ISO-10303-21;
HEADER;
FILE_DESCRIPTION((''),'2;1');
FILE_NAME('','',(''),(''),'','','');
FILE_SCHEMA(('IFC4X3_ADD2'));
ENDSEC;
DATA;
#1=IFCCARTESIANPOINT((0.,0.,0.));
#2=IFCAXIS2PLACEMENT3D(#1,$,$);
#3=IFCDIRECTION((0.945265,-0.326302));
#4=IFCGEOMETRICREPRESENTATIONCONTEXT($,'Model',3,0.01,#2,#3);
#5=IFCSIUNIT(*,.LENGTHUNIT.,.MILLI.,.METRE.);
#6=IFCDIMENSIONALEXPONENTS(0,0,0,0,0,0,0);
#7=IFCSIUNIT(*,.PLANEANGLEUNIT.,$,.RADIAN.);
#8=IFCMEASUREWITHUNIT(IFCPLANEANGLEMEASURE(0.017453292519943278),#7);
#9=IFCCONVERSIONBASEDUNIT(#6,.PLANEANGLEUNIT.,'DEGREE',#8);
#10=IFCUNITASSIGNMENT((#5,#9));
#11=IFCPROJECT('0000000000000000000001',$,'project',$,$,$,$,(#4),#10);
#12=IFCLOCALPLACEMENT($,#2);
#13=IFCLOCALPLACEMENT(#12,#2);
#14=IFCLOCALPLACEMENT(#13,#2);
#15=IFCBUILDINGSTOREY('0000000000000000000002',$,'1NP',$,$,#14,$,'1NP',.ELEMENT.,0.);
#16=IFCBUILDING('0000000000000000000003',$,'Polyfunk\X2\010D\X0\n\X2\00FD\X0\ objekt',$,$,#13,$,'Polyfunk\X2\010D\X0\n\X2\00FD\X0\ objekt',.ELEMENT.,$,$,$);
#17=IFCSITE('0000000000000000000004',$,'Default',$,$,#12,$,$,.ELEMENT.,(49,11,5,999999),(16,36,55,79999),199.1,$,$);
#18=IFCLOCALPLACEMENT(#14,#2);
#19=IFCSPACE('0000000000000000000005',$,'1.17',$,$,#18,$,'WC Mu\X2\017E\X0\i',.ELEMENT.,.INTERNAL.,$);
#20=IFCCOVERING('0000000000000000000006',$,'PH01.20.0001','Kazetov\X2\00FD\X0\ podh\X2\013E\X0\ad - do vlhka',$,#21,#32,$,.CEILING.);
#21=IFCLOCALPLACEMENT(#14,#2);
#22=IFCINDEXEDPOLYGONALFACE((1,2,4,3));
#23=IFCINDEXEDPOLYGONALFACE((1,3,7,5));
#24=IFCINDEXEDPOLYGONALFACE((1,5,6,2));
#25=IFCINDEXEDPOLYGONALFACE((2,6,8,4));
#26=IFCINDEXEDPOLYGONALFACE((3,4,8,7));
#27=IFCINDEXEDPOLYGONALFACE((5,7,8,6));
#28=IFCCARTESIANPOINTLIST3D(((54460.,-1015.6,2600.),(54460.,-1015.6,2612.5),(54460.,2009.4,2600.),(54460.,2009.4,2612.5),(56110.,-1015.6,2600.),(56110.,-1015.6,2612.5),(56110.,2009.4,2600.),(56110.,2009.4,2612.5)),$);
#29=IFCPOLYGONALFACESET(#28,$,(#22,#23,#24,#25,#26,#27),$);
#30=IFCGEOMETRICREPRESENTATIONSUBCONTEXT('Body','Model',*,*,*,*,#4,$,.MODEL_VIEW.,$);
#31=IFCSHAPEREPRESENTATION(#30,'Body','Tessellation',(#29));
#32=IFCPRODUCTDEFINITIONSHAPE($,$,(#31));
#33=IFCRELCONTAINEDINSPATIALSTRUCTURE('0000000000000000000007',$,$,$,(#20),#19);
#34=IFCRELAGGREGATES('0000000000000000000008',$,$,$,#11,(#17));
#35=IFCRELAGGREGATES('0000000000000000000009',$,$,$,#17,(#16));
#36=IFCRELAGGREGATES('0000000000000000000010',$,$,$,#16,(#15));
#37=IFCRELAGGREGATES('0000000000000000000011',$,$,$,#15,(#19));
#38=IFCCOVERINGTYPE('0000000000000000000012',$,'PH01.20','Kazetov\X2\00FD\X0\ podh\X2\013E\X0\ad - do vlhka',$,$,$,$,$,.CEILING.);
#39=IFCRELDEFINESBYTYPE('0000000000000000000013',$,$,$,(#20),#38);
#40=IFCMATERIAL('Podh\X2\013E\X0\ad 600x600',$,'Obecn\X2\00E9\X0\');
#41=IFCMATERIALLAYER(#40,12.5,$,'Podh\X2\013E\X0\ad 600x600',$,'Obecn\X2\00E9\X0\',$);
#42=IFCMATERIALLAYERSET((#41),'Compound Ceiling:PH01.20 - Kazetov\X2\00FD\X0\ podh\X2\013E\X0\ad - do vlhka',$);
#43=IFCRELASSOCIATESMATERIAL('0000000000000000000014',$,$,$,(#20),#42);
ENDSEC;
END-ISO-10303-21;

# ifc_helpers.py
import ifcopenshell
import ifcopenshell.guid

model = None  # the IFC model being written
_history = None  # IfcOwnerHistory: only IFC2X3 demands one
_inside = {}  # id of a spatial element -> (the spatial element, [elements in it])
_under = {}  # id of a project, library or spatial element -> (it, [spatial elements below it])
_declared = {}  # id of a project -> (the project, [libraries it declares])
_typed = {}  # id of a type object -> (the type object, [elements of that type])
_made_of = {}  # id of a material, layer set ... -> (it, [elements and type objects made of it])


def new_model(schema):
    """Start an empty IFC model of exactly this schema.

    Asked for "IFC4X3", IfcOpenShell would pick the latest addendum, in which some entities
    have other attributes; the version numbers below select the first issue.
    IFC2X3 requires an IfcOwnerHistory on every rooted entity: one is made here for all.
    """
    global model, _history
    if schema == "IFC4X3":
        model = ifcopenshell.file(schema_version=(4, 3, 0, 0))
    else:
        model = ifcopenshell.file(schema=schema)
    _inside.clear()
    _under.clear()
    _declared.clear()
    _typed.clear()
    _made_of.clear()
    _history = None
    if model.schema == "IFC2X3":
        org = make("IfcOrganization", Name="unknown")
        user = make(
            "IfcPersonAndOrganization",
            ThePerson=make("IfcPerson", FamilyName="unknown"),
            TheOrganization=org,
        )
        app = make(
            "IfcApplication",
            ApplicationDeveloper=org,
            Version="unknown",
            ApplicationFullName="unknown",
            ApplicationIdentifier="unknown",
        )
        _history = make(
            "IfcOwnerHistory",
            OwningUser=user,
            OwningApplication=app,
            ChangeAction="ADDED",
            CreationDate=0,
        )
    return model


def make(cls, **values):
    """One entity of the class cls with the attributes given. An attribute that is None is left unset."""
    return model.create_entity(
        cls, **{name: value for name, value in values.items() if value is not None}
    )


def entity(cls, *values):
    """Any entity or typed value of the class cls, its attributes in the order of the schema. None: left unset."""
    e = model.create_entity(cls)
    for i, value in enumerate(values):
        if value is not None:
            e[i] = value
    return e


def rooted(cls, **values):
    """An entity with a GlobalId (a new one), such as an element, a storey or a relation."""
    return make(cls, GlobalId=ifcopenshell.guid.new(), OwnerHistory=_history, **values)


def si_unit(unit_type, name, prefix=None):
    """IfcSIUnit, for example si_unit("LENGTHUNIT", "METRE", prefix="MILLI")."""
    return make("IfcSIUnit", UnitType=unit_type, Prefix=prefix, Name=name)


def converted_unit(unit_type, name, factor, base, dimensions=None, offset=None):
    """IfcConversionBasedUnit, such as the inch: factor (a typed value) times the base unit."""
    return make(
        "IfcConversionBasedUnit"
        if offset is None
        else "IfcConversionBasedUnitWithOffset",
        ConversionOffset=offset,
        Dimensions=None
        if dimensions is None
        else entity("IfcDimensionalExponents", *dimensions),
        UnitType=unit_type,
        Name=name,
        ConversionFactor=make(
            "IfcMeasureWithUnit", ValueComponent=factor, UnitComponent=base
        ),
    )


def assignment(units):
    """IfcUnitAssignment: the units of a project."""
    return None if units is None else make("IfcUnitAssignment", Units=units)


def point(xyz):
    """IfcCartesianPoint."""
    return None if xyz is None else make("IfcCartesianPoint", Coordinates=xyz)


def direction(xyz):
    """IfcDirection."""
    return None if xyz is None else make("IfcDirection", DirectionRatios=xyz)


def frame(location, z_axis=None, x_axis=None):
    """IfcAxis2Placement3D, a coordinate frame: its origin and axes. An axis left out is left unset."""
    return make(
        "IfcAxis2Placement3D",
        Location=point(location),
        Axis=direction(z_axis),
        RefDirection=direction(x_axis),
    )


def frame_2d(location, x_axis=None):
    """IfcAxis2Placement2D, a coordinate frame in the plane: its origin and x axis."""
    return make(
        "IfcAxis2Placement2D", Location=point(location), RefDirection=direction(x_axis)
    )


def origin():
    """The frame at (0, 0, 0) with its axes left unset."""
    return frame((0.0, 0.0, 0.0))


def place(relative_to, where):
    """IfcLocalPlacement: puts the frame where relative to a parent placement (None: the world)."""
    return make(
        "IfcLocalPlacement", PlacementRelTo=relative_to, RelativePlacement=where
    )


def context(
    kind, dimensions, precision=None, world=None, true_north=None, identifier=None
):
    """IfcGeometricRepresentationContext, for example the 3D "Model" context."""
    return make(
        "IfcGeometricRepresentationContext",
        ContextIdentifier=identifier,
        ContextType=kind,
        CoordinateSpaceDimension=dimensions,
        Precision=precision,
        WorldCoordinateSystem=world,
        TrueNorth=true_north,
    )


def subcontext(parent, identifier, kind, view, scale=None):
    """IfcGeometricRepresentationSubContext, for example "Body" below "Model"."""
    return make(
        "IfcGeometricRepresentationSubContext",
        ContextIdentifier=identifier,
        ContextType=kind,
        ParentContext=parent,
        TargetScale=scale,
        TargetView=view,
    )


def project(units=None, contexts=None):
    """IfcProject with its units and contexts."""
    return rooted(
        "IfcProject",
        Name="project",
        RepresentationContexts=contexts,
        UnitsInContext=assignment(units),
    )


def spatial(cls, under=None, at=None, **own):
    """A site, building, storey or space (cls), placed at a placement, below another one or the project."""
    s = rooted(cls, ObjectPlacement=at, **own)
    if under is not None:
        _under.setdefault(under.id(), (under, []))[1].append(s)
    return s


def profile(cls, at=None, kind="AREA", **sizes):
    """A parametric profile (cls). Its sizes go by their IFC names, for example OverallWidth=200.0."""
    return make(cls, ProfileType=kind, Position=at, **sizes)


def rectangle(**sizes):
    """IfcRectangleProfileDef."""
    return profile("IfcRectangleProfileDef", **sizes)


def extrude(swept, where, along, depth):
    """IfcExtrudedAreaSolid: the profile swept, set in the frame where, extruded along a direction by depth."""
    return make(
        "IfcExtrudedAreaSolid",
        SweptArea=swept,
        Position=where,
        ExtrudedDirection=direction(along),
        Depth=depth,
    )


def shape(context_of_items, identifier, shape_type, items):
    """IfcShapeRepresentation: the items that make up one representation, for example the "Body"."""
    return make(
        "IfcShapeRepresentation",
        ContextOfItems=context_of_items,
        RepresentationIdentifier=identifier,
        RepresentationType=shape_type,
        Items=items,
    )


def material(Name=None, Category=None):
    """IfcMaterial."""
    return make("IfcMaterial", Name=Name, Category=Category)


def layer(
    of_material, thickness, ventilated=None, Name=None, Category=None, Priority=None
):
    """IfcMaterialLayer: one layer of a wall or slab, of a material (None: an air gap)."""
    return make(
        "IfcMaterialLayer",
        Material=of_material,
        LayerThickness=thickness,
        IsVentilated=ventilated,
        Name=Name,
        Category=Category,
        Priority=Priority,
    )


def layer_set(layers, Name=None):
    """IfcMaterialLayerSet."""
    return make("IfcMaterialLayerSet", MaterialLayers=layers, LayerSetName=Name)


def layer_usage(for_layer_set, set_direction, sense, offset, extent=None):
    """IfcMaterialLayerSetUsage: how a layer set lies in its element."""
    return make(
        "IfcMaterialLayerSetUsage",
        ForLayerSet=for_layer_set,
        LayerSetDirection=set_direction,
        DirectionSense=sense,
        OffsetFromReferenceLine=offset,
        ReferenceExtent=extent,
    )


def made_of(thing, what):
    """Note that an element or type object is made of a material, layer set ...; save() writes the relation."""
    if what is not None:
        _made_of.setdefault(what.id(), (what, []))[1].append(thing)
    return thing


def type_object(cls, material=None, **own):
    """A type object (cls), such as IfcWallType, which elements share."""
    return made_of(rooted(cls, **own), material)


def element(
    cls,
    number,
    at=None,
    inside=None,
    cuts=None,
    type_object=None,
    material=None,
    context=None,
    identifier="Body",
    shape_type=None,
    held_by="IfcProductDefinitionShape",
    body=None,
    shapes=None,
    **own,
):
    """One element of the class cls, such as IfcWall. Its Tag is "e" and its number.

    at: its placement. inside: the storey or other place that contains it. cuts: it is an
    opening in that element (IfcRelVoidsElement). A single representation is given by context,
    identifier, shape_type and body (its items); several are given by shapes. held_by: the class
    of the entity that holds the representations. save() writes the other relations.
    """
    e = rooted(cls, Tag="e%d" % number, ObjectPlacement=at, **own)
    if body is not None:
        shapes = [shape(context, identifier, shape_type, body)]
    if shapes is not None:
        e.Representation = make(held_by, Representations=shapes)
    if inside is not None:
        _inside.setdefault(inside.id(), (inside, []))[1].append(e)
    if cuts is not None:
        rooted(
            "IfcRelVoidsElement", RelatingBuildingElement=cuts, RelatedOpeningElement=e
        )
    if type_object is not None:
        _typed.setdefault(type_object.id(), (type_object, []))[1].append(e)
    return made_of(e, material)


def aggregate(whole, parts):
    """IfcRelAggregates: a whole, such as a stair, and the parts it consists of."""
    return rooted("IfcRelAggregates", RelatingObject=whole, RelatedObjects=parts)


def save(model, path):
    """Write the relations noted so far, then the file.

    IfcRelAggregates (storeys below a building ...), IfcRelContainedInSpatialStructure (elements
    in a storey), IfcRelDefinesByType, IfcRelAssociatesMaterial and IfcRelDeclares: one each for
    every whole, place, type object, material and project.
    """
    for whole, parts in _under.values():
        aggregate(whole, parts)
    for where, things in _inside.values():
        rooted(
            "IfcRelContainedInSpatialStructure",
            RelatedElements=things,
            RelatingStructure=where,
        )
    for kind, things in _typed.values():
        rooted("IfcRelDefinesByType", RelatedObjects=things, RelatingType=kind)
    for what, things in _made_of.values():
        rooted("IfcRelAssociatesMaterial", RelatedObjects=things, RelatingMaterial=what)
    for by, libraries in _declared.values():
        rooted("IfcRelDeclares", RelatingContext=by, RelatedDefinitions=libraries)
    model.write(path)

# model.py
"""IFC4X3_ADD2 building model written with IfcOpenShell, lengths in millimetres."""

from ifc_helpers import new_model, entity, si_unit, converted_unit, direction, frame, frame_2d, origin, place, context, subcontext, project, spatial, rectangle, extrude, material, layer, layer_set, layer_usage, type_object, element, save


model = new_model("IFC4X3_ADD2")

# Units and contexts
model_context = context("Model", 3, precision=0.01, world=origin(), true_north=direction((0.945265, -0.326302)))
body_context = subcontext(model_context, "Body", "Model", "MODEL_VIEW")
ifc_project = project(units=[si_unit("LENGTHUNIT", "METRE", prefix="MILLI"), converted_unit("PLANEANGLEUNIT", "DEGREE", entity("IfcPlaneAngleMeasure", 0.017453292519943278), si_unit("PLANEANGLEUNIT", "RADIAN"), dimensions=[0, 0, 0, 0, 0, 0, 0])], contexts=[model_context])

# Site, building, storey
site_placement = place(None, origin())
site = spatial("IfcSite", under=ifc_project, at=site_placement, Name="Default", CompositionType="ELEMENT", RefLatitude=(49, 11, 5, 999999), RefLongitude=(16, 36, 55, 79999), RefElevation=199.1)
building_placement = place(site_placement, origin())
building = spatial("IfcBuilding", under=site, at=building_placement, Name="Polyfunkčný objekt", LongName="Polyfunkčný objekt", CompositionType="ELEMENT")
storey_placement = place(building_placement, origin())
storey = spatial("IfcBuildingStorey", under=building, at=storey_placement, Name="1NP", LongName="1NP", CompositionType="ELEMENT", Elevation=0.0)

# Shared definitions
ifc_material_1 = material(Name="Podhľad 600x600", Category="Obecné")

# Shared definitions
ifc_layer_1 = layer(ifc_material_1, 12.5, Name="Podhľad 600x600", Category="Obecné")
ifc_layer_set_1 = layer_set([ifc_layer_1], Name="Compound Ceiling:PH01.20 - Kazetový podhľad - do vlhka")
covering_type_1 = type_object("IfcCoveringType", Name="PH01.20", Description="Kazetový podhľad - do vlhka", PredefinedType="CEILING")

# Shared definitions
space_1_placement = place(storey_placement, origin())
space_1 = spatial("IfcSpace", under=storey, at=space_1_placement, Name="1.17", LongName="WC Muži", CompositionType="ELEMENT", PredefinedType="INTERNAL")

# Covering
ifc_layer_usage_1 = layer_usage(ifc_layer_set_1, "AXIS3", "NEGATIVE", 0.0)
covering_1_placement = place(storey_placement, frame((54460.0, -1015.6, 2600.0)))
element("IfcCovering", 1, at=covering_1_placement, inside=space_1, type_object=covering_type_1, material=ifc_layer_usage_1, Name="PH01.20.0001", Description="Kazetový podhľad - do vlhka", PredefinedType="CEILING", context=body_context, shape_type="SweptSolid", body=[
    extrude(rectangle(XDim=1650.0, YDim=3025.0, at=frame_2d((0.0, 0.0), x_axis=(1.0, 0.0))), frame((825.0, 1512.5, 0.0), z_axis=(0.0, 0.0, 1.0), x_axis=(-1.0, 0.0, 0.0)), (0.0, 0.0, 1.0), 12.5),
])

save(model, "model.ifc")
